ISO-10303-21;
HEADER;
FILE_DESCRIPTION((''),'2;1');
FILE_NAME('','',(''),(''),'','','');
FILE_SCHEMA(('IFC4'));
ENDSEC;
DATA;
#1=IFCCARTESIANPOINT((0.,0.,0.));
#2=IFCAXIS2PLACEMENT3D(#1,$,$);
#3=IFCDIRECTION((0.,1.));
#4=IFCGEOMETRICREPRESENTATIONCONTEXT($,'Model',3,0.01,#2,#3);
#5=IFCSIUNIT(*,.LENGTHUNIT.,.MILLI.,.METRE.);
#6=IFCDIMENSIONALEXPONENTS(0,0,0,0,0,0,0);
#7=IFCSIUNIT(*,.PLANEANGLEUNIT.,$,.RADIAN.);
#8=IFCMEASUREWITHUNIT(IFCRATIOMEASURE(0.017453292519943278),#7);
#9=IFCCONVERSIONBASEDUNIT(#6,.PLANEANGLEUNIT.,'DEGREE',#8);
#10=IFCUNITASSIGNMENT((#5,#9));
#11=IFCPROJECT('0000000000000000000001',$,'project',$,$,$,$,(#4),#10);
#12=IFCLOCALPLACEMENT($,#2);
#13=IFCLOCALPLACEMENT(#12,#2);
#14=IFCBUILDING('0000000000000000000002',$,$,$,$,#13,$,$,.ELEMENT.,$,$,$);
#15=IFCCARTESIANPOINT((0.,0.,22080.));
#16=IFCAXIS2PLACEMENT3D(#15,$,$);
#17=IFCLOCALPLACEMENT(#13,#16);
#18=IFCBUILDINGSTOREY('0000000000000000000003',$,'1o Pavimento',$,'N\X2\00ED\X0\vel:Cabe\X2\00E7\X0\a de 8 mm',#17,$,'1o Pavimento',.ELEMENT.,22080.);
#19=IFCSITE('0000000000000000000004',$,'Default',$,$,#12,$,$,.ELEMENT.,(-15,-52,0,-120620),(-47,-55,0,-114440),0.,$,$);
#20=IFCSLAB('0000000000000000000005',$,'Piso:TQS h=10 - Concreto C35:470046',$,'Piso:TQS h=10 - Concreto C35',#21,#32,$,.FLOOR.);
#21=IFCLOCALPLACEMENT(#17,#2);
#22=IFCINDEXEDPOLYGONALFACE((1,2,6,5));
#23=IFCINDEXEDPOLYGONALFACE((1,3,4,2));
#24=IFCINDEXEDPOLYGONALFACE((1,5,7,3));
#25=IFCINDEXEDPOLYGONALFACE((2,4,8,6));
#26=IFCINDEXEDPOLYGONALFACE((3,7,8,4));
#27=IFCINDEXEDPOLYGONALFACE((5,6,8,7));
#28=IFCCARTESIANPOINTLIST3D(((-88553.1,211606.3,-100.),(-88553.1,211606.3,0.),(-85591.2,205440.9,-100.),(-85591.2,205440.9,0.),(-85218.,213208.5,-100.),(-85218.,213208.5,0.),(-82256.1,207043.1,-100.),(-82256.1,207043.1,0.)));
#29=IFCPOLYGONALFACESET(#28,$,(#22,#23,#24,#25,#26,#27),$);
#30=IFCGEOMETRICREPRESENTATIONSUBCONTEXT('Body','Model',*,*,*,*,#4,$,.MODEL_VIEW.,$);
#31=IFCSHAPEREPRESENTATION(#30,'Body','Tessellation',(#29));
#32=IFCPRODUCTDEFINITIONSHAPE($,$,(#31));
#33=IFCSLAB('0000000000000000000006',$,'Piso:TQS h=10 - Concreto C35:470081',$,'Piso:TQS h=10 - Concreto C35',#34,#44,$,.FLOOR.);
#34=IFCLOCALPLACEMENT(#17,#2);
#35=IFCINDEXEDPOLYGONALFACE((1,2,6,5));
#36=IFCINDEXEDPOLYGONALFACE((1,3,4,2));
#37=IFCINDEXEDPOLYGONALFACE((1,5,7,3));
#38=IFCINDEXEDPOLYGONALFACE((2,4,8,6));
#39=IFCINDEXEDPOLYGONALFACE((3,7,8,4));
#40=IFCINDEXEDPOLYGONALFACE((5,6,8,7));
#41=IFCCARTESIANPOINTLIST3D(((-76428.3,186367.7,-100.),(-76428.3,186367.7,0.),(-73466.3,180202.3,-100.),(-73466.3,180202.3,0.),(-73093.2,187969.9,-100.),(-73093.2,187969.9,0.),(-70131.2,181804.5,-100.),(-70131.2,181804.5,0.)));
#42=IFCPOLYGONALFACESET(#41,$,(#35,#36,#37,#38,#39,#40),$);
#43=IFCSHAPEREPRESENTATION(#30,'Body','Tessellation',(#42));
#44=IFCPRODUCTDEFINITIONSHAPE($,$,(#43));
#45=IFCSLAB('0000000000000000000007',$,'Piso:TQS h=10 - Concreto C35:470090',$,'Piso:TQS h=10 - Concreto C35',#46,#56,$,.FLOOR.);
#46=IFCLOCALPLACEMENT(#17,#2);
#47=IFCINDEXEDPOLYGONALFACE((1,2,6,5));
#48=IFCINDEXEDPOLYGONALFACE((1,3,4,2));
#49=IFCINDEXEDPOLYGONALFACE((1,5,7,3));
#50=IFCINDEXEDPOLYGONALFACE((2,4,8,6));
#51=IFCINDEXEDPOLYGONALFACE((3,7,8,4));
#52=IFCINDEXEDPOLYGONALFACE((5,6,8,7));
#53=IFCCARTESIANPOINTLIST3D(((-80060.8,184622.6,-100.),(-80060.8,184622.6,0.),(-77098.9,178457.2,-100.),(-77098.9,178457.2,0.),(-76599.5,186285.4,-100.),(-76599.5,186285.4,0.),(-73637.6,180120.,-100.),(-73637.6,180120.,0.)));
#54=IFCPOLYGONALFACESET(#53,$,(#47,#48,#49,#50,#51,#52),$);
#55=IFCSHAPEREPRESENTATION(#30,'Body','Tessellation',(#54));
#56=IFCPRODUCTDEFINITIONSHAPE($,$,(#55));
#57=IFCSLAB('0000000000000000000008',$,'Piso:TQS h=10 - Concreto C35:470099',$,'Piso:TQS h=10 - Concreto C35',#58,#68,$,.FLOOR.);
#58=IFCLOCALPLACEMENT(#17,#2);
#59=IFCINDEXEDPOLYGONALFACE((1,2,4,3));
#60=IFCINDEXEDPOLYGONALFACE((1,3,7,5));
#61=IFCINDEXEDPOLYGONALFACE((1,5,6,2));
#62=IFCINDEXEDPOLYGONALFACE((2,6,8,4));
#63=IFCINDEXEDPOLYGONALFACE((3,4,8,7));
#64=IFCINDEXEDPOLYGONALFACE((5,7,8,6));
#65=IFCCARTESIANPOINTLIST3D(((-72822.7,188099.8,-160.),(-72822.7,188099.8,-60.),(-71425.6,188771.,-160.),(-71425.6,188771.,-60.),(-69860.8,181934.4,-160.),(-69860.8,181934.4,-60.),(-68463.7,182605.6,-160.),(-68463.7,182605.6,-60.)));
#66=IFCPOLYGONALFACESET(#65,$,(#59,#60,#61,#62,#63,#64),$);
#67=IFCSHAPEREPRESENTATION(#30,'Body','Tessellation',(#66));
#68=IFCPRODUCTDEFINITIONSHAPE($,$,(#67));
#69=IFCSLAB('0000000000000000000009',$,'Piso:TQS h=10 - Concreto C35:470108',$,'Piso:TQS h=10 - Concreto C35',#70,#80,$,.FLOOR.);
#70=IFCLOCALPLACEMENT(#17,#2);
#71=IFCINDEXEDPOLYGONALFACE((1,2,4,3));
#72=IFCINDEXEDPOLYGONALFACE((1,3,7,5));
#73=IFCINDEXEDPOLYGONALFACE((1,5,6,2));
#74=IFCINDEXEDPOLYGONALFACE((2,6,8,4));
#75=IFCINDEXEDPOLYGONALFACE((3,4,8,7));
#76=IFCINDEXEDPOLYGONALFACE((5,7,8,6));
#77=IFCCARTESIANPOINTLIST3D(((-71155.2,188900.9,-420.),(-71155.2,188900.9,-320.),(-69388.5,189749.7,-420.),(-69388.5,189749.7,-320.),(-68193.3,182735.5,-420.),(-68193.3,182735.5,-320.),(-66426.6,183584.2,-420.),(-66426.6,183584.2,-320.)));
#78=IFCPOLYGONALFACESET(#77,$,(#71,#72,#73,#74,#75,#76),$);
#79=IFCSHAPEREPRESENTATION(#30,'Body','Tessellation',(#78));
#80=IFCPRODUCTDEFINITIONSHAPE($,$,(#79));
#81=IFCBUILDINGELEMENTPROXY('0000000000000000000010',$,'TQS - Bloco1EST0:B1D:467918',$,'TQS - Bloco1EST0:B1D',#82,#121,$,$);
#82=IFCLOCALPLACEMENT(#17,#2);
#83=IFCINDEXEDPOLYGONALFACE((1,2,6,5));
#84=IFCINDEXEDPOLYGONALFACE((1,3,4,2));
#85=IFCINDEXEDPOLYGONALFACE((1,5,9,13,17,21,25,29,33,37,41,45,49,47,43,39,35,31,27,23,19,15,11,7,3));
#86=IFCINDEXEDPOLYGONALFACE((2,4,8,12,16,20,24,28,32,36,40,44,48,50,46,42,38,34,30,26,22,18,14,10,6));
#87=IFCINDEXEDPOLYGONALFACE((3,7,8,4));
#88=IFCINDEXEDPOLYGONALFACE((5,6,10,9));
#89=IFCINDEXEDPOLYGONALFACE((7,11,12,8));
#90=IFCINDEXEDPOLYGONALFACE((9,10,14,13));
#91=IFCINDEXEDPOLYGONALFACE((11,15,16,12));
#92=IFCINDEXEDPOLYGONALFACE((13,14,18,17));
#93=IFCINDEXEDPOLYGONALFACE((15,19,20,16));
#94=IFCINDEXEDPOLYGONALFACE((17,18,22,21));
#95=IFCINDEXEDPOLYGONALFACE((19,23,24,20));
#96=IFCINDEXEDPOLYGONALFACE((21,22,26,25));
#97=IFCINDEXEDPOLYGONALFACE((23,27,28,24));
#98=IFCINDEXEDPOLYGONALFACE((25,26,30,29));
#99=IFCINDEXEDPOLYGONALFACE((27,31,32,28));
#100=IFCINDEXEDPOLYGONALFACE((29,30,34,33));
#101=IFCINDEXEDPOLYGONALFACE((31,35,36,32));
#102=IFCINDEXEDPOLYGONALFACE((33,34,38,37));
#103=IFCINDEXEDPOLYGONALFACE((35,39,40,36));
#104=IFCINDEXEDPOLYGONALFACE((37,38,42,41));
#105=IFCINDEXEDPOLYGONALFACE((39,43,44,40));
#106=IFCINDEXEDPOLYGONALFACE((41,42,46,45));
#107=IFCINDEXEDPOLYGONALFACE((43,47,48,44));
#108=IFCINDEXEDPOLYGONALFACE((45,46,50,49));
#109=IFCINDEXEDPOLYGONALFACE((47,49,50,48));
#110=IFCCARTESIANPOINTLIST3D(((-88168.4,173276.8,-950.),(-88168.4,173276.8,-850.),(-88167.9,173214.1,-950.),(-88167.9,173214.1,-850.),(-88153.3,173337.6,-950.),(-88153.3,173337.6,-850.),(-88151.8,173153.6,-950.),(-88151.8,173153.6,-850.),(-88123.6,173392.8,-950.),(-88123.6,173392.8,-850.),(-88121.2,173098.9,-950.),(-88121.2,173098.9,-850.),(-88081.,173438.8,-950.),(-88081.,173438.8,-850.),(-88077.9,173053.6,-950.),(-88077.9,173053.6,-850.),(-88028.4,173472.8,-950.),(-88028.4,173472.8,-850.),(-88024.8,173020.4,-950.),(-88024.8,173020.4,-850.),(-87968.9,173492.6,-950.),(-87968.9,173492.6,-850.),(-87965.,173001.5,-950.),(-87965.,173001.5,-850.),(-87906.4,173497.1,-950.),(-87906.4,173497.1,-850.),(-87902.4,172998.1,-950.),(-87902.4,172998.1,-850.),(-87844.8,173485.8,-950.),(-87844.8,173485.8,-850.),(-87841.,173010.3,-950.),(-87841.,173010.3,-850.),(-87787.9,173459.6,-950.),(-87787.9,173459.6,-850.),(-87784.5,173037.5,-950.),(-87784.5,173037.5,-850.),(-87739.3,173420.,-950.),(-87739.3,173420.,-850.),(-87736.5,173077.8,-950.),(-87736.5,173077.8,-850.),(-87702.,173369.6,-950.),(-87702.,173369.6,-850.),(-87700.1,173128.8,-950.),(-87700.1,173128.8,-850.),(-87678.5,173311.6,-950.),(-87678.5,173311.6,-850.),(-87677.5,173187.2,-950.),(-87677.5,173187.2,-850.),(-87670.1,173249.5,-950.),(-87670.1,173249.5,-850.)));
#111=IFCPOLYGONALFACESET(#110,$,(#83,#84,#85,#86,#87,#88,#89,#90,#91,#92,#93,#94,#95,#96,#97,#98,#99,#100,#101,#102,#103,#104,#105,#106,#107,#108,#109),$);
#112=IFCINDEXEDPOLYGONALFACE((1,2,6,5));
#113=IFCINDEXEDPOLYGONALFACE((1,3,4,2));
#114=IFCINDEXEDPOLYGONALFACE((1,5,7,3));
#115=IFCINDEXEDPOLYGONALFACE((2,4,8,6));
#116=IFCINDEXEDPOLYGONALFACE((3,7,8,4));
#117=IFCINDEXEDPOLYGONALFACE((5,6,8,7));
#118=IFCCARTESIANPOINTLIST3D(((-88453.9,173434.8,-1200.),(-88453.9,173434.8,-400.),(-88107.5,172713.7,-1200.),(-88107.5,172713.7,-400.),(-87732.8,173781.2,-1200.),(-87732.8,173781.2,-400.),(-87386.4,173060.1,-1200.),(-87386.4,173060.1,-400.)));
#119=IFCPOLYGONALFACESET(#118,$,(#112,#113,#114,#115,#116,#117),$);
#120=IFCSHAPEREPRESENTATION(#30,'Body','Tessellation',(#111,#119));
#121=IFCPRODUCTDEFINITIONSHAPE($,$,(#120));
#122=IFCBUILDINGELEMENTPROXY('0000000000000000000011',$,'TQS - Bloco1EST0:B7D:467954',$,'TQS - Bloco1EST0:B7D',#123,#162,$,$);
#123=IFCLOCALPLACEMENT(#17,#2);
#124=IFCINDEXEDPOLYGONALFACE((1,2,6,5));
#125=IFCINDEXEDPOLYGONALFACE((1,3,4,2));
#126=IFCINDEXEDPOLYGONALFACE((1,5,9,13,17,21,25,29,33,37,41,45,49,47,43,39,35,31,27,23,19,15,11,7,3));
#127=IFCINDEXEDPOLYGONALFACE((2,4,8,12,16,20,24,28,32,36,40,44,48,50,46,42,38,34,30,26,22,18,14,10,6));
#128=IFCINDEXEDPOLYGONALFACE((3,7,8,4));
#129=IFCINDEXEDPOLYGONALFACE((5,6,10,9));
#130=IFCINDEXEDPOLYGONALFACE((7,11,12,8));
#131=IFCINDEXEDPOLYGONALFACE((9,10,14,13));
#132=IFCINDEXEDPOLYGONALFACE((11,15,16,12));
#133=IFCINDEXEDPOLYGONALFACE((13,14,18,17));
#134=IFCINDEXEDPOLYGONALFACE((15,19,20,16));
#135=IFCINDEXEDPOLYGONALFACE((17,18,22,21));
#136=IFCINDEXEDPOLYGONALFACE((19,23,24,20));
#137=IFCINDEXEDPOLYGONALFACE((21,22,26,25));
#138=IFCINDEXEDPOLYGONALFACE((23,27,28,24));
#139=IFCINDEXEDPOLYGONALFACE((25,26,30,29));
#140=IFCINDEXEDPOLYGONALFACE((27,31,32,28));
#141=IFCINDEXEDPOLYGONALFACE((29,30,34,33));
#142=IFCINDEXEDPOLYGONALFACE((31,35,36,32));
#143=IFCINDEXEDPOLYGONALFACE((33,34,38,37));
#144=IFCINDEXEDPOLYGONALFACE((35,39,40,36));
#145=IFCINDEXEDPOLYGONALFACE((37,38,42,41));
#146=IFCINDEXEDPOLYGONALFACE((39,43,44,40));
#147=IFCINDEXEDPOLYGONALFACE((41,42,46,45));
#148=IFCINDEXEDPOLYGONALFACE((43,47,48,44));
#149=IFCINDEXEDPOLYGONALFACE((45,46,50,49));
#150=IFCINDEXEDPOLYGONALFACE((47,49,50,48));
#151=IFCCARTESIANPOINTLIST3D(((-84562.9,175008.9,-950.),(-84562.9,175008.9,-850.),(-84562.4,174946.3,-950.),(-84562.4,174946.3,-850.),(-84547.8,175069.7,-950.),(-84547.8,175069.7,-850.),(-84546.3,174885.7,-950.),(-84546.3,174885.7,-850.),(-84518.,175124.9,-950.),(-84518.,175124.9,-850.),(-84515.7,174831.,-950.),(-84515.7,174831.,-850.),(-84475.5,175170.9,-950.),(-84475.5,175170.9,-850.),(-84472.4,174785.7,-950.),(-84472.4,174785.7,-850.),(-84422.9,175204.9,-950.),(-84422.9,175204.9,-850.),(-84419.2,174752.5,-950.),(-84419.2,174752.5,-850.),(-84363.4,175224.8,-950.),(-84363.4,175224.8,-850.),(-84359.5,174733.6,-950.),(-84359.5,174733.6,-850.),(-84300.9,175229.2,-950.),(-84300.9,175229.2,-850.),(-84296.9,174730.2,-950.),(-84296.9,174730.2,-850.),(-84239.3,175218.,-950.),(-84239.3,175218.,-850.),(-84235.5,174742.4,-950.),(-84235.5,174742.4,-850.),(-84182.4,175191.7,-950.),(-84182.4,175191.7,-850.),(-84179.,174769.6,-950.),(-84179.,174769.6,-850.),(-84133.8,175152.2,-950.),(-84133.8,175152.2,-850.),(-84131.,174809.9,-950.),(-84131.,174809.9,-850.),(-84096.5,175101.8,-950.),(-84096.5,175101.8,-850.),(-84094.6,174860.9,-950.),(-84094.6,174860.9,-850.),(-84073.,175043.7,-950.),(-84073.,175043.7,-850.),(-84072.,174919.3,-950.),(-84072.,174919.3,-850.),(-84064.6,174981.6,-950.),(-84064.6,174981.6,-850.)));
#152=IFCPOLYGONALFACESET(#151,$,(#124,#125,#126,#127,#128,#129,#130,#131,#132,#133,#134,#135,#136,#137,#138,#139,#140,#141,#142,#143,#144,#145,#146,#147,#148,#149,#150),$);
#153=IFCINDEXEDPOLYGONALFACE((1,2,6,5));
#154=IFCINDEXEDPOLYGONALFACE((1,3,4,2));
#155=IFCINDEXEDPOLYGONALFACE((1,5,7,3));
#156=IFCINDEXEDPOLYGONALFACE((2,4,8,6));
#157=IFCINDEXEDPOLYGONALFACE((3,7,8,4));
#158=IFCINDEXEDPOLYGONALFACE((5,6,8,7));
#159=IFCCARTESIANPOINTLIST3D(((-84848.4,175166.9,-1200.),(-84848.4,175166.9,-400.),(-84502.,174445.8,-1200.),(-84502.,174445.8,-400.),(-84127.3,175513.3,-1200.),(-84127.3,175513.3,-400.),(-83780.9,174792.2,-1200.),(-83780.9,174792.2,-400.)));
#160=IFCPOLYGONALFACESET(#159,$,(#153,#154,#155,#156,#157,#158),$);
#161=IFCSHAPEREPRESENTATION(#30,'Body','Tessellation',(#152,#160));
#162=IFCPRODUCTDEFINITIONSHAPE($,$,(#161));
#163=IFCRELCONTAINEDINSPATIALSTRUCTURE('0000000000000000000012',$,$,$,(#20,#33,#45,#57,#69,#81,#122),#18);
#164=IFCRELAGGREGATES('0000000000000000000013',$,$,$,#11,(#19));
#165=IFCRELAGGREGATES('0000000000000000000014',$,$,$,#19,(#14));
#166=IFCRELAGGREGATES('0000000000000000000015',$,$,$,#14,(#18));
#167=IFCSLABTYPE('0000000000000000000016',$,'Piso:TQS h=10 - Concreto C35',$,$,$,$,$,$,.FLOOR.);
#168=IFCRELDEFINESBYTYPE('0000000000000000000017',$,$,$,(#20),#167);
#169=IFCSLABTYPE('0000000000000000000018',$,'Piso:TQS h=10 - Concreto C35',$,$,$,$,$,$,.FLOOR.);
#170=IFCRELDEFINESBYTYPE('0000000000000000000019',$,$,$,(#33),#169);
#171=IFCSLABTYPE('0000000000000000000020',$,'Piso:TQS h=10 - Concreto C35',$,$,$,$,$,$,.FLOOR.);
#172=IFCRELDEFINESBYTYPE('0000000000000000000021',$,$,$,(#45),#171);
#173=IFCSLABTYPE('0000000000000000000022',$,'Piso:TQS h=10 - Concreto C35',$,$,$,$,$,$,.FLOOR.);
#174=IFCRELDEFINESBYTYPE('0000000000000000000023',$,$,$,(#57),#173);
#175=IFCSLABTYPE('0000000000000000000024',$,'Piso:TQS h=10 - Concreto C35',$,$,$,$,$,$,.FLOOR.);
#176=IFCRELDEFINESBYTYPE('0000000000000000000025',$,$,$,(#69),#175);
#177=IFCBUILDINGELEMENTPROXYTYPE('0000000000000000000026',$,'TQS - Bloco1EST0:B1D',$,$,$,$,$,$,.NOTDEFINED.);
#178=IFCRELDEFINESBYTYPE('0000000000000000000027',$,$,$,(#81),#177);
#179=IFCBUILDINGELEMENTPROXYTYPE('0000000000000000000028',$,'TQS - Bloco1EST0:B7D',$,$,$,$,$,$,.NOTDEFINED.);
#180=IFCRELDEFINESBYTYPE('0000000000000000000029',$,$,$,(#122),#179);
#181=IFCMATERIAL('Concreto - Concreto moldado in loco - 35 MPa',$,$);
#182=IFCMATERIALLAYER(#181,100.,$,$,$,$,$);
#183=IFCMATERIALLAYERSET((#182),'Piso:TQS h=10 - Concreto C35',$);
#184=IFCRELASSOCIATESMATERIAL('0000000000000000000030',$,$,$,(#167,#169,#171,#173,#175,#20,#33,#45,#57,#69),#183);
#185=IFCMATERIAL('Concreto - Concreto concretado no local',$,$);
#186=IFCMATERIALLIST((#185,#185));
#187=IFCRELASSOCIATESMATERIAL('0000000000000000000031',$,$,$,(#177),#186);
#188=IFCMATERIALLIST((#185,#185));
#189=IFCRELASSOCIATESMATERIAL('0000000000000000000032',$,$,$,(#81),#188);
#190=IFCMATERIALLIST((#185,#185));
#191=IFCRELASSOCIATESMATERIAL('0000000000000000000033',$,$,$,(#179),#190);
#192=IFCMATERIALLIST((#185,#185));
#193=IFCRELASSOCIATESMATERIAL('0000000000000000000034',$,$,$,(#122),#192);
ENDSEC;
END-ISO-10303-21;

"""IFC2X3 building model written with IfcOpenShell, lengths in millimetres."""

from ifc_helpers import new_model, entity, si_unit, converted_unit, direction, frame, frame_2d, origin, origin_2d_with_axis, place, context, subcontext, project, spatial, rectangle, circle, extrude, source, transform, mapped, material, material_list, layer, layer_set, layer_usage, type_object, type_shapes, element, save


model = new_model("IFC2X3")

# Units and contexts
model_context = context("Model", 3, precision=0.01, world=origin(), true_north=direction((0.0, 1.0)))
body_context = subcontext(model_context, "Body", "Model", "MODEL_VIEW")
ifc_project = project(units=[si_unit("LENGTHUNIT", "METRE", prefix="MILLI"), converted_unit("PLANEANGLEUNIT", "DEGREE", entity("IfcRatioMeasure", 0.017453292519943278), si_unit("PLANEANGLEUNIT", "RADIAN"), dimensions=[0, 0, 0, 0, 0, 0, 0])], contexts=[model_context])

# Site, building, storey
site_placement = place(None, origin())
site = spatial("IfcSite", under=ifc_project, at=site_placement, Name="Default", CompositionType="ELEMENT", RefLatitude=(-15, -52, 0, -120620), RefLongitude=(-47, -55, 0, -114440), RefElevation=0.0)
building_placement = place(site_placement, origin())
building = spatial("IfcBuilding", under=site, at=building_placement, CompositionType="ELEMENT")
storey_placement = place(building_placement, frame((0.0, 0.0, 22080.0)))
storey = spatial("IfcBuildingStorey", under=building, at=storey_placement, Name="1o Pavimento", ObjectType="Nível:Cabeça de 8 mm", LongName="1o Pavimento", CompositionType="ELEMENT", Elevation=22080.0)

# Shared definitions
ifc_material_1 = material(Name="Concreto - Concreto moldado in loco - 35 MPa")

# Slabs
ifc_layer_1 = layer(ifc_material_1, 100.0)
ifc_layer_set_1 = layer_set([ifc_layer_1], Name="Piso:TQS h=10 - Concreto C35")
ifc_layer_usage_1 = layer_usage(ifc_layer_set_1, "AXIS3", "POSITIVE", 0.0)
slab_type_1 = type_object("IfcSlabType", Name="Piso:TQS h=10 - Concreto C35", PredefinedType="FLOOR", material=ifc_layer_set_1)
slab_1_placement = place(storey_placement, origin())
element("IfcSlab", 1, at=slab_1_placement, inside=storey, type_object=slab_type_1, material=ifc_layer_usage_1, Name="Piso:TQS h=10 - Concreto C35:470046", ObjectType="Piso:TQS h=10 - Concreto C35", PredefinedType="FLOOR", context=body_context, shape_type="SweptSolid", body=[
    extrude(rectangle(XDim=6840.0, YDim=3700.0, at=frame_2d((0.0, 0.0), x_axis=(1.0, 0.0))), frame((-85404.6, 209324.7, 0.0), z_axis=(0.0, 0.0, -1.0), x_axis=(0.43303, -0.90138, 0.0)), (0.0, 0.0, 1.0), 100.0),
])
ifc_layer_usage_2 = layer_usage(ifc_layer_set_1, "AXIS3", "POSITIVE", 0.0)
slab_type_2 = type_object("IfcSlabType", Name="Piso:TQS h=10 - Concreto C35", PredefinedType="FLOOR", material=ifc_layer_set_1)
slab_2_placement = place(storey_placement, origin())
element("IfcSlab", 2, at=slab_2_placement, inside=storey, type_object=slab_type_2, material=ifc_layer_usage_2, Name="Piso:TQS h=10 - Concreto C35:470081", ObjectType="Piso:TQS h=10 - Concreto C35", PredefinedType="FLOOR", context=body_context, shape_type="SweptSolid", body=[
    extrude(rectangle(XDim=6840.0, YDim=3700.0, at=frame_2d((0.0, 0.0), x_axis=(1.0, 0.0))), frame((-73279.7, 184086.1, 0.0), z_axis=(0.0, 0.0, -1.0), x_axis=(0.43303, -0.90138, 0.0)), (0.0, 0.0, 1.0), 100.0),
])
ifc_layer_usage_3 = layer_usage(ifc_layer_set_1, "AXIS3", "POSITIVE", 0.0)
slab_type_3 = type_object("IfcSlabType", Name="Piso:TQS h=10 - Concreto C35", PredefinedType="FLOOR", material=ifc_layer_set_1)
slab_3_placement = place(storey_placement, origin())
element("IfcSlab", 3, at=slab_3_placement, inside=storey, type_object=slab_type_3, material=ifc_layer_usage_3, Name="Piso:TQS h=10 - Concreto C35:470090", ObjectType="Piso:TQS h=10 - Concreto C35", PredefinedType="FLOOR", context=body_context, shape_type="SweptSolid", body=[
    extrude(rectangle(XDim=6840.0, YDim=3840.0, at=frame_2d((0.0, 0.0), x_axis=(1.0, 0.0))), frame((-76849.2, 182371.3, 0.0), z_axis=(0.0, 0.0, -1.0), x_axis=(0.43303, -0.90138, 0.0)), (0.0, 0.0, 1.0), 100.0),
])
ifc_layer_usage_4 = layer_usage(ifc_layer_set_1, "AXIS3", "POSITIVE", 0.0)
slab_type_4 = type_object("IfcSlabType", Name="Piso:TQS h=10 - Concreto C35", PredefinedType="FLOOR", material=ifc_layer_set_1)
slab_4_placement = place(storey_placement, origin())
element("IfcSlab", 4, at=slab_4_placement, inside=storey, type_object=slab_type_4, material=ifc_layer_usage_4, Name="Piso:TQS h=10 - Concreto C35:470099", ObjectType="Piso:TQS h=10 - Concreto C35", PredefinedType="FLOOR", context=body_context, shape_type="SweptSolid", body=[
    extrude(rectangle(XDim=1550.0, YDim=6840.0, at=frame_2d((0.0, 0.0), x_axis=(1.0, 0.0))), frame((-70643.2, 185352.7, -60.0), z_axis=(0.0, 0.0, -1.0), x_axis=(0.90138, 0.43303, 0.0)), (0.0, 0.0, 1.0), 100.0),
])
ifc_layer_usage_5 = layer_usage(ifc_layer_set_1, "AXIS3", "POSITIVE", 0.0)
slab_type_5 = type_object("IfcSlabType", Name="Piso:TQS h=10 - Concreto C35", PredefinedType="FLOOR", material=ifc_layer_set_1)
slab_5_placement = place(storey_placement, origin())
element("IfcSlab", 5, at=slab_5_placement, inside=storey, type_object=slab_type_5, material=ifc_layer_usage_5, Name="Piso:TQS h=10 - Concreto C35:470108", ObjectType="Piso:TQS h=10 - Concreto C35", PredefinedType="FLOOR", context=body_context, shape_type="SweptSolid", body=[
    extrude(rectangle(XDim=6840.0, YDim=1960.0, at=frame_2d((0.0, 0.0), x_axis=(1.0, 0.0))), frame((-68790.9, 186242.6, -320.0), z_axis=(0.0, 0.0, -1.0), x_axis=(0.43303, -0.90138, 0.0)), (0.0, 0.0, 1.0), 100.0),
])

# Building element proxies
ifc_material_2 = material(Name="Concreto - Concreto concretado no local")
ifc_material_list_1 = material_list([ifc_material_2, ifc_material_2])
ifc_material_list_2 = material_list([ifc_material_2, ifc_material_2])
building_element_proxy_type_1 = type_object("IfcBuildingElementProxyType", Name="TQS - Bloco1EST0:B1D", PredefinedType="NOTDEFINED", material=ifc_material_list_2)
shared_shape_1 = source(origin(), body_context, "Body", "SweptSolid", [
    extrude(circle(Radius=250.0, at=frame_2d((0.0, 0.0), x_axis=(1.0, 0.0))), frame((0.0, 0.0, -550.0)), (0.0, 0.0, 1.0), 100.0),
    extrude(rectangle(XDim=800.0, YDim=800.0, at=origin_2d_with_axis()), frame((0.0, 0.0, -800.0), z_axis=(0.0, 0.0, 1.0), x_axis=(-1.0, 0.0, 0.0)), (0.0, 0.0, 1.0), 800.0),
])
type_shapes(building_element_proxy_type_1, [shared_shape_1])
proxy_1_placement = place(storey_placement, frame((-87920.1, 173247.5, -400.0), z_axis=(0.0, 0.0, 1.0), x_axis=(-0.43303, 0.90138, 0.0)))
element("IfcBuildingElementProxy", 6, at=proxy_1_placement, inside=storey, type_object=building_element_proxy_type_1, material=ifc_material_list_1, Name="TQS - Bloco1EST0:B1D:467918", ObjectType="TQS - Bloco1EST0:B1D", context=body_context, shape_type="MappedRepresentation", body=[
    mapped(shared_shape_1, transform((0.0, 0.0, 0.0), scale=1.0)),
])
ifc_material_list_3 = material_list([ifc_material_2, ifc_material_2])
ifc_material_list_4 = material_list([ifc_material_2, ifc_material_2])
building_element_proxy_type_2 = type_object("IfcBuildingElementProxyType", Name="TQS - Bloco1EST0:B7D", PredefinedType="NOTDEFINED", material=ifc_material_list_4)
shared_shape_2 = source(origin(), body_context, "Body", "SweptSolid", [
    extrude(circle(Radius=250.0, at=frame_2d((0.0, 0.0), x_axis=(1.0, 0.0))), frame((0.0, 0.0, -550.0)), (0.0, 0.0, 1.0), 100.0),
    extrude(rectangle(XDim=800.0, YDim=800.0, at=origin_2d_with_axis()), frame((0.0, 0.0, -800.0), z_axis=(0.0, 0.0, 1.0), x_axis=(-1.0, 0.0, 0.0)), (0.0, 0.0, 1.0), 800.0),
])
type_shapes(building_element_proxy_type_2, [shared_shape_2])
proxy_2_placement = place(storey_placement, frame((-84314.6, 174979.6, -400.0), z_axis=(0.0, 0.0, 1.0), x_axis=(-0.43303, 0.90138, 0.0)))
element("IfcBuildingElementProxy", 7, at=proxy_2_placement, inside=storey, type_object=building_element_proxy_type_2, material=ifc_material_list_3, Name="TQS - Bloco1EST0:B7D:467954", ObjectType="TQS - Bloco1EST0:B7D", context=body_context, shape_type="MappedRepresentation", body=[
    mapped(shared_shape_2, transform((0.0, 0.0, 0.0), scale=1.0)),
])

save(model, "model.ifc")
